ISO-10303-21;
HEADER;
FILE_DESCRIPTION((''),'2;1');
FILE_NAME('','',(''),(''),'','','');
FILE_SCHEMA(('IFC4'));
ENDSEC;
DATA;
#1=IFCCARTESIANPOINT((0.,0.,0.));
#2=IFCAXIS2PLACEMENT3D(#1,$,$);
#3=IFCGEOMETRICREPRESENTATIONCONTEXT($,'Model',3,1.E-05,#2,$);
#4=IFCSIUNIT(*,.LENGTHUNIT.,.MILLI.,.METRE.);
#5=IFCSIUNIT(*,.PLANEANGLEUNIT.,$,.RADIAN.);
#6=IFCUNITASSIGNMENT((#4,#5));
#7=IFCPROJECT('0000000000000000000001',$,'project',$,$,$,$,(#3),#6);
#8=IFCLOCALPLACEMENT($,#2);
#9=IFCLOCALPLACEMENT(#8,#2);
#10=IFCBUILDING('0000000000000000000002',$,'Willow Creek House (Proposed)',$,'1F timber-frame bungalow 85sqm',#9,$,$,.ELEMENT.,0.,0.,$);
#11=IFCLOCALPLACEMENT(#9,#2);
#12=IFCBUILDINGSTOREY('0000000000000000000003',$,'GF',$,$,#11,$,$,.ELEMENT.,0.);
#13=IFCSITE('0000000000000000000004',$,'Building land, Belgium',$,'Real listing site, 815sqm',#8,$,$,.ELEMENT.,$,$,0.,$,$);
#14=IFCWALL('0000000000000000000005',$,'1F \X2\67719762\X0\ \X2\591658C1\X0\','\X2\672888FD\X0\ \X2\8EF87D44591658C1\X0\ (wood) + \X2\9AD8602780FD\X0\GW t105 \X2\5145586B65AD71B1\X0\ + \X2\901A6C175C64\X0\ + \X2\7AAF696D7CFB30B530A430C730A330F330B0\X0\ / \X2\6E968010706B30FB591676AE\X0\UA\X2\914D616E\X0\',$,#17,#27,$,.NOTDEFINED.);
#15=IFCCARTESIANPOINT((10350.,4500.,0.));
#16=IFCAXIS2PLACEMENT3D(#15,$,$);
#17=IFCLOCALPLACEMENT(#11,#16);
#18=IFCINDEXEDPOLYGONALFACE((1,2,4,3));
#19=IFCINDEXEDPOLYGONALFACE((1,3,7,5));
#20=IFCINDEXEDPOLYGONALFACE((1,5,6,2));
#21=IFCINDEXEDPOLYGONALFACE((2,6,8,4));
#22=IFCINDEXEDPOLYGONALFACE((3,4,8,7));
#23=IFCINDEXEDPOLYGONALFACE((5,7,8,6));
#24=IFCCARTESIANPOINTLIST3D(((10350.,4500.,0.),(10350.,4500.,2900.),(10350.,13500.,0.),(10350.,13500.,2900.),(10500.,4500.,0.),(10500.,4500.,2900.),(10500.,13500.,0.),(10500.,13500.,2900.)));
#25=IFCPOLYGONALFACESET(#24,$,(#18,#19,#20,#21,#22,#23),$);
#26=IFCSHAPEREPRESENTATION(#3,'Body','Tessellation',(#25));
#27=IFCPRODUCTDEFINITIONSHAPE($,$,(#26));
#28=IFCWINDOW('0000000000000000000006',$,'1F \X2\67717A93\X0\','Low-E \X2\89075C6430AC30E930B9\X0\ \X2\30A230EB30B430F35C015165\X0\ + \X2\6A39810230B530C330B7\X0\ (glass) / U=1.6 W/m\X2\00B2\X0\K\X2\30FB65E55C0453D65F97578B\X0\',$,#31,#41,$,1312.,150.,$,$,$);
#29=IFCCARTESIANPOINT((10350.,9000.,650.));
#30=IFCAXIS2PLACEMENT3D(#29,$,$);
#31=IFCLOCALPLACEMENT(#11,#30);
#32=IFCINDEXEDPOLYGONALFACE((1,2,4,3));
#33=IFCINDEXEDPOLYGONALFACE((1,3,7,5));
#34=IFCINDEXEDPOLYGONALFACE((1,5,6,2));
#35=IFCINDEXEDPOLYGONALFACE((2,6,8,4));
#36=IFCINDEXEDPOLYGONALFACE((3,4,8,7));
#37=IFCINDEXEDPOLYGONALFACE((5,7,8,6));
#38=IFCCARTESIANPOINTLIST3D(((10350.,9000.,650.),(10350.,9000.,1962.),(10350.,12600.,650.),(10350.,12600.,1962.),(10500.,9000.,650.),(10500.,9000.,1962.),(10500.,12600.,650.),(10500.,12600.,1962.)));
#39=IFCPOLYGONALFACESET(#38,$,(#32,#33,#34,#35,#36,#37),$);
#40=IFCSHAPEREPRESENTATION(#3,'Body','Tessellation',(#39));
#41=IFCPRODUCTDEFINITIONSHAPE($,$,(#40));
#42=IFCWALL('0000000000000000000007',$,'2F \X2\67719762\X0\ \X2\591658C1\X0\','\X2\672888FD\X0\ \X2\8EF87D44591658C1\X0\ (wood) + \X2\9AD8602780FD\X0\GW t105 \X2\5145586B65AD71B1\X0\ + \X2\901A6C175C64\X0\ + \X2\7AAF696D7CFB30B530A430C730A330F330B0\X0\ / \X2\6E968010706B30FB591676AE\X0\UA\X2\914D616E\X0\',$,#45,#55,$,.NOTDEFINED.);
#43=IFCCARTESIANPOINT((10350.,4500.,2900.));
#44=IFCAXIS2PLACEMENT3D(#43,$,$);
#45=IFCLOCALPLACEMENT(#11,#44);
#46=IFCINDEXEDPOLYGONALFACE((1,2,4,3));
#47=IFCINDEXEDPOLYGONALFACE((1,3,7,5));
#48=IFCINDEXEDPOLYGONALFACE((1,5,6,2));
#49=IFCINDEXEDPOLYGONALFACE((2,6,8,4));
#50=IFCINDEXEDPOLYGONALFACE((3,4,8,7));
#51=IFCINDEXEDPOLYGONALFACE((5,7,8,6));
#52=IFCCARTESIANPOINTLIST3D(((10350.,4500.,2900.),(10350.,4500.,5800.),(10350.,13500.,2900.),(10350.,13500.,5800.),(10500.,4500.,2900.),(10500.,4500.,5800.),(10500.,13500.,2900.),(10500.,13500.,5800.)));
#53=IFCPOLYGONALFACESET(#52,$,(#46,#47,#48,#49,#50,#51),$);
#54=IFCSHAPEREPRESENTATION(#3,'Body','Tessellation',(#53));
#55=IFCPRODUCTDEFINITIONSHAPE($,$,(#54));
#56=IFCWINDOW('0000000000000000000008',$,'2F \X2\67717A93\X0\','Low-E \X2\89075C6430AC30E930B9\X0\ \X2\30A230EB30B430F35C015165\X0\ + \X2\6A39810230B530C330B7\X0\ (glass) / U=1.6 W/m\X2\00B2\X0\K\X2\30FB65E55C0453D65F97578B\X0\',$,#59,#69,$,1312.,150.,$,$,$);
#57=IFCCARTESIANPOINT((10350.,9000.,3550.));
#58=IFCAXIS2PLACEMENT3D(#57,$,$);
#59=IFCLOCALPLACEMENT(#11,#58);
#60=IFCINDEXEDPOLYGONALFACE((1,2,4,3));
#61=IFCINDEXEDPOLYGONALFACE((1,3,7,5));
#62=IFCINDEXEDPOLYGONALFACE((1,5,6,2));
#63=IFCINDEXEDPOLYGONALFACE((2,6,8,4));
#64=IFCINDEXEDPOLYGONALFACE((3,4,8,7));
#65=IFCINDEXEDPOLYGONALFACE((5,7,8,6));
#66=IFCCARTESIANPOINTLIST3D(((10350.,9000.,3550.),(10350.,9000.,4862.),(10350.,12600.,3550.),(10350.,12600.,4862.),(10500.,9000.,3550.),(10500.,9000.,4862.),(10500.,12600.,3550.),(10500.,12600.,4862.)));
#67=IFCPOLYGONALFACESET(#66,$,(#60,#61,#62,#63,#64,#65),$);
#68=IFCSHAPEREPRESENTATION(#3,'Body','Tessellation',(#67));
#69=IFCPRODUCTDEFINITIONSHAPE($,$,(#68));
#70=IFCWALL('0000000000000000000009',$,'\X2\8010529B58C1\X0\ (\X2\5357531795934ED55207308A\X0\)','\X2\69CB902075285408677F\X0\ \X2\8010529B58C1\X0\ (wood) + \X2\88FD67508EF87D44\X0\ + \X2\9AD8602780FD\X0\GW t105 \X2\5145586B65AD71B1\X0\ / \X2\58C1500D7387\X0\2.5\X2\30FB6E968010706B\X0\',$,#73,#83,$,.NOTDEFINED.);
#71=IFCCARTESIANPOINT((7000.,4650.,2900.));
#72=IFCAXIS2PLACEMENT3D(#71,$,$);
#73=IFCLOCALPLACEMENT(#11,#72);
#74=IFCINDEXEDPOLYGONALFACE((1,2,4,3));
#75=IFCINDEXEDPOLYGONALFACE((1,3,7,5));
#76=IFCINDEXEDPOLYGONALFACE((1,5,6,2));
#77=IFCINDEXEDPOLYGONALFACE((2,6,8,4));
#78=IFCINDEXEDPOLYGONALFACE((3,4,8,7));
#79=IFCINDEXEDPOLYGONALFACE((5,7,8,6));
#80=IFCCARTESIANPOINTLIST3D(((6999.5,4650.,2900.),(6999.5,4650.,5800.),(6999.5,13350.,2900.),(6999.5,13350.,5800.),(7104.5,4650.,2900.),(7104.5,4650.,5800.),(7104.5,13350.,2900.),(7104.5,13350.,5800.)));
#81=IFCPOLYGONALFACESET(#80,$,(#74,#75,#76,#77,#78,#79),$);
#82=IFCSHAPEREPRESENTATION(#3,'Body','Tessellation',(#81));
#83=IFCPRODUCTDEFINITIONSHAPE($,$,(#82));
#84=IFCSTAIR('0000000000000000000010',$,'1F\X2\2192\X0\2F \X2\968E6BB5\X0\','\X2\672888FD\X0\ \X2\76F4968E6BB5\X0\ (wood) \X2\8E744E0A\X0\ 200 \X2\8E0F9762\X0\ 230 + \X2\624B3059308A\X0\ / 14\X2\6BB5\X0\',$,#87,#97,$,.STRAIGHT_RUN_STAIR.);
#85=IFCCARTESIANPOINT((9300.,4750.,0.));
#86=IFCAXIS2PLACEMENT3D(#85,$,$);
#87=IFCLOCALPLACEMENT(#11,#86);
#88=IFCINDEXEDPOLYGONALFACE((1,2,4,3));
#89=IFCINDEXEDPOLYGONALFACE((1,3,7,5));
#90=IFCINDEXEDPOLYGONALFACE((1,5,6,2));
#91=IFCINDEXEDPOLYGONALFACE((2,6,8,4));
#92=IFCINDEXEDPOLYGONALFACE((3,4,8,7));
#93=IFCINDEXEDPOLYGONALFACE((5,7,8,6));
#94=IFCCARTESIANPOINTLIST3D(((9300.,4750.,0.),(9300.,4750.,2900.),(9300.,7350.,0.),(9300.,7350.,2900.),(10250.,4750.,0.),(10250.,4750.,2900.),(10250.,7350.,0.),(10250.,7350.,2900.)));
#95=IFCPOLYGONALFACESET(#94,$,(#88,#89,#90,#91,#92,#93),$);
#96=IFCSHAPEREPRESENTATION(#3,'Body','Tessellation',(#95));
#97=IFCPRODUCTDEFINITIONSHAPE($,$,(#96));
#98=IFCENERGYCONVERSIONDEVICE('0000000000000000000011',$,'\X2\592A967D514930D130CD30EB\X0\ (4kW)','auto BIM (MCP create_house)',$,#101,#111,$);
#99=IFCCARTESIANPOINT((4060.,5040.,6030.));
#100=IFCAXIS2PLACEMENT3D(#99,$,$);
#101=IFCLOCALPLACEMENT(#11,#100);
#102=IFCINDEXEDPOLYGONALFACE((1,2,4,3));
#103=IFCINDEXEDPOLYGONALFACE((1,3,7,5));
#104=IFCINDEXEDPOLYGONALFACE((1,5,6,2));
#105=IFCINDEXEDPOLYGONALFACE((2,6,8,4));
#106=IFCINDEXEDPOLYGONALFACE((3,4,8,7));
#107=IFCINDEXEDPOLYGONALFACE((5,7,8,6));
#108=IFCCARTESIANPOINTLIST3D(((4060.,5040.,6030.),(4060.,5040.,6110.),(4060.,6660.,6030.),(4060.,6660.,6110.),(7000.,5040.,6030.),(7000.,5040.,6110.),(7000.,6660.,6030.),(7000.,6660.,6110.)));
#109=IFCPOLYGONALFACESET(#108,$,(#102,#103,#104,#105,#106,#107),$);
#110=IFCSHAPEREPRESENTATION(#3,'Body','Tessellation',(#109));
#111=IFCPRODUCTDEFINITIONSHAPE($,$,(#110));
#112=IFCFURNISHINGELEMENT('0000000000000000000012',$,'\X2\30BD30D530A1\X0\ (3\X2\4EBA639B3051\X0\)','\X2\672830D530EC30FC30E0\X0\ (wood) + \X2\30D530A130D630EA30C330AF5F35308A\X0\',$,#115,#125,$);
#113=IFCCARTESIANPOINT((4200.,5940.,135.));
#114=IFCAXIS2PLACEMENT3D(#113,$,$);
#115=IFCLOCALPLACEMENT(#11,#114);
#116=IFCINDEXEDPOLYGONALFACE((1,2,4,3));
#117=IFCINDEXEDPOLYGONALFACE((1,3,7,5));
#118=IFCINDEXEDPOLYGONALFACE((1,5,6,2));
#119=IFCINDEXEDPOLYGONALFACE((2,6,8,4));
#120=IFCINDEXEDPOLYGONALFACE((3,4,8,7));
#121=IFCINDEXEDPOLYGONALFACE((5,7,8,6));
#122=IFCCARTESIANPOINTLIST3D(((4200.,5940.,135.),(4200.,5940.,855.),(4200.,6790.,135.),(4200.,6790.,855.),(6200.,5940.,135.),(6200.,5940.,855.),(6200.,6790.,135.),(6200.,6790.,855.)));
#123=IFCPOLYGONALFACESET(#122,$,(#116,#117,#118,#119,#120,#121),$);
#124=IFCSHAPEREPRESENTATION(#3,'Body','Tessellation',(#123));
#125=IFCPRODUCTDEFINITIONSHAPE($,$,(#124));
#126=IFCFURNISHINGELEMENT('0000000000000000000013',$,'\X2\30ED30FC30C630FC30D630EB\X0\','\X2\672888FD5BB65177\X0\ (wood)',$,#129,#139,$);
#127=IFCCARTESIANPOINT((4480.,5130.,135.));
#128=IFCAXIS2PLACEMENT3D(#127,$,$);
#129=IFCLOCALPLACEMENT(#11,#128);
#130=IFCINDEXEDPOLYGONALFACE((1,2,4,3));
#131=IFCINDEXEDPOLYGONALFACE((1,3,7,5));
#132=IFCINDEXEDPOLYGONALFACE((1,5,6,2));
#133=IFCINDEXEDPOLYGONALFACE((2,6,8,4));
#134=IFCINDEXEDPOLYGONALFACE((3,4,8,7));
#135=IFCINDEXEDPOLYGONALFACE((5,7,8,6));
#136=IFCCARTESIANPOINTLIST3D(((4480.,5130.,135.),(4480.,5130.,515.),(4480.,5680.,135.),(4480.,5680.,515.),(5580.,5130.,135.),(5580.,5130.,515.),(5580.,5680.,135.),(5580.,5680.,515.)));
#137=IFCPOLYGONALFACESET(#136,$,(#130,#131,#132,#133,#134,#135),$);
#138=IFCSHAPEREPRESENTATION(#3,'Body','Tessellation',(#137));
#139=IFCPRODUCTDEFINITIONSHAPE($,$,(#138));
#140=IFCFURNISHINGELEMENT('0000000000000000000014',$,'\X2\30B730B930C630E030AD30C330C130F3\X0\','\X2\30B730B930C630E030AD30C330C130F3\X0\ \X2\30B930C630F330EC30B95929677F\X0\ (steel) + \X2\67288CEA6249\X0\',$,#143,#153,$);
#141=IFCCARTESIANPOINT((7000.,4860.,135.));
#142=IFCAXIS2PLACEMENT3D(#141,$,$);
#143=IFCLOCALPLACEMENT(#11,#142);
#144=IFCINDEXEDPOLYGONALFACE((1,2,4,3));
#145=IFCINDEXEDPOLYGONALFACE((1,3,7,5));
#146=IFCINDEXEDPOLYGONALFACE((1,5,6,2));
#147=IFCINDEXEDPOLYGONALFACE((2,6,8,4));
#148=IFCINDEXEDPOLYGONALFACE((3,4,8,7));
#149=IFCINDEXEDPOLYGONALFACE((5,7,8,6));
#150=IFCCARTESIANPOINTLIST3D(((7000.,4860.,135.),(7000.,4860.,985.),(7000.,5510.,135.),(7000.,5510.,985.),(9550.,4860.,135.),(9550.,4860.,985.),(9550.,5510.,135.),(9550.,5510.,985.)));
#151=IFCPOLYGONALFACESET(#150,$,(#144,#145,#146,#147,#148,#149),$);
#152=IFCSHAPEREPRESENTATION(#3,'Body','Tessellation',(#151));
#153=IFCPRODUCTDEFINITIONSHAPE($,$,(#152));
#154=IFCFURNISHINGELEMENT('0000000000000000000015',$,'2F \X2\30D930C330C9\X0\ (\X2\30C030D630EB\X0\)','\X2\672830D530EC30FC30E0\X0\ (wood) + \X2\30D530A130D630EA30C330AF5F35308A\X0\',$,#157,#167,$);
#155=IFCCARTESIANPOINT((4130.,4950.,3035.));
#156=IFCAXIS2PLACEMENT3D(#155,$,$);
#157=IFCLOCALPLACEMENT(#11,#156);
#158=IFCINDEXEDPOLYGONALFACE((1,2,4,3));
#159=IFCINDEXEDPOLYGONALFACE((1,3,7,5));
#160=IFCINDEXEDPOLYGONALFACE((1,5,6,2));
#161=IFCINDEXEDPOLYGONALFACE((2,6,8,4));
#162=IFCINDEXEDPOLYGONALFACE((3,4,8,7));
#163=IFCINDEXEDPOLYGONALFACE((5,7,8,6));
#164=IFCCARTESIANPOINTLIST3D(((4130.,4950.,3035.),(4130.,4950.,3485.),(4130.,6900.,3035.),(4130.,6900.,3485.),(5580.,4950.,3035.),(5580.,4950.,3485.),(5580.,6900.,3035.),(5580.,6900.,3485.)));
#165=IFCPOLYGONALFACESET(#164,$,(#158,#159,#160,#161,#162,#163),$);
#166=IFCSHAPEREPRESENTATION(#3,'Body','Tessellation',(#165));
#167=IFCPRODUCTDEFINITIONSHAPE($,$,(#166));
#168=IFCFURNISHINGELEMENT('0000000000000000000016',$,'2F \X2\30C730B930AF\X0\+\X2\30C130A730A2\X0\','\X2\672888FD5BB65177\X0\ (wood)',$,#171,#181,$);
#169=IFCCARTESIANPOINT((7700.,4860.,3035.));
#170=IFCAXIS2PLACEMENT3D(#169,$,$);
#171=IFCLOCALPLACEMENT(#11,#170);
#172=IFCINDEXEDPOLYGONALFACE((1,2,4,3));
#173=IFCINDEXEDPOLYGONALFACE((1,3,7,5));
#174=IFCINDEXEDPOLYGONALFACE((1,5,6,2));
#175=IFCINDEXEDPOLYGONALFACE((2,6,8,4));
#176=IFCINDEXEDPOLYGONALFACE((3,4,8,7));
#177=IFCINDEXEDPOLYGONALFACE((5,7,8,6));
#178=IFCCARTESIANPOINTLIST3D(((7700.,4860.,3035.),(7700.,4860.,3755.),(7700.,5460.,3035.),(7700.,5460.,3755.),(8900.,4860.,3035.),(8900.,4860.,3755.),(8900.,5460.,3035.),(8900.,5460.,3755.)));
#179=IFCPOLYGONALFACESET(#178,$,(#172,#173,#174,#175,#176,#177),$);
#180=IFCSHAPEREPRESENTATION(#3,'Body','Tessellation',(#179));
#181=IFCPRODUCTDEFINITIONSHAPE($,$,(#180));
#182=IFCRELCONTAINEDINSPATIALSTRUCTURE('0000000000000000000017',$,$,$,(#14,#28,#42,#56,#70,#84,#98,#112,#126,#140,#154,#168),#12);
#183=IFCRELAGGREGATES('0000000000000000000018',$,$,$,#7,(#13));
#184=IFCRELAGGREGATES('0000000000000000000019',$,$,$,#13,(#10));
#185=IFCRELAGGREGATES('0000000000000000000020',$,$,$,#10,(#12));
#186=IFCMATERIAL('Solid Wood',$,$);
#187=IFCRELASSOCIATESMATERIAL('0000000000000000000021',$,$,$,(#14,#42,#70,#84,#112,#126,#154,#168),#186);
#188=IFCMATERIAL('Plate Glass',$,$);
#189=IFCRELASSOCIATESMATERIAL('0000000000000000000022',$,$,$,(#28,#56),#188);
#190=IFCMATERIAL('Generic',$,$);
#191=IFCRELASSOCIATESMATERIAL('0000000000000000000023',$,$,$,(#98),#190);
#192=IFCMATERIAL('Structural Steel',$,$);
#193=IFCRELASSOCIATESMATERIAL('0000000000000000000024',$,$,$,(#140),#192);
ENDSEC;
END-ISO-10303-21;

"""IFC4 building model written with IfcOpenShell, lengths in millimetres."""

from ifc_helpers import new_model, si_unit, frame, frame_2d, origin, place, context, project, spatial, rectangle, extrude, material, element, fill, save


model = new_model("IFC4")

# Units and contexts
model_context = context("Model", 3, precision=1e-05, world=origin())
ifc_project = project(units=[si_unit("LENGTHUNIT", "METRE", prefix="MILLI"), si_unit("PLANEANGLEUNIT", "RADIAN")], contexts=[model_context])

# Site, building, storey
site_placement = place(None, origin())
site = spatial("IfcSite", under=ifc_project, at=site_placement, Name="Building land, Belgium", ObjectType="Real listing site, 815sqm", CompositionType="ELEMENT", RefElevation=0.0)
building_placement = place(site_placement, origin())
building = spatial("IfcBuilding", under=site, at=building_placement, Name="Willow Creek House (Proposed)", ObjectType="1F timber-frame bungalow 85sqm", CompositionType="ELEMENT", ElevationOfRefHeight=0.0, ElevationOfTerrain=0.0)
storey_placement = place(building_placement, origin())
storey = spatial("IfcBuildingStorey", under=building, at=storey_placement, Name="GF", CompositionType="ELEMENT", Elevation=0.0)

# Wall, opening, window
ifc_material_1 = material(Name="Solid Wood")
wall_1_placement = place(storey_placement, frame((10350.0, 4500.0, 0.0)))
wall_1 = element("IfcWall", 1, at=wall_1_placement, inside=storey, material=ifc_material_1, Name="1F 東面 外壁", Description="木製 軸組外壁 (wood) + 高性能GW t105 充填断熱 + 通気層 + 窯業系サイディング / 準耐火・外皮UA配慮", PredefinedType="NOTDEFINED", context=model_context, shape_type="SweptSolid", body=[
    extrude(rectangle(XDim=150.0, YDim=9000.0, at=frame_2d((75.0, 4500.0))), frame((10350.0, 4500.0, 0.0)), (0.0, 0.0, 1.0), 2900.0),
])
opening_1_placement = place(storey_placement, frame((10350.0, 9000.0, 650.0)))
opening_1 = element("IfcOpeningElement", 2, at=opening_1_placement, cuts=wall_1, PredefinedType="NOTDEFINED", context=model_context, shape_type="SweptSolid", body=[
    extrude(rectangle(XDim=150.0, YDim=3600.0, at=frame_2d((75.0, 1800.0))), frame((10350.0, 9000.0, 650.0)), (0.0, 0.0, 1.0), 1312.0),
])
ifc_material_2 = material(Name="Plate Glass")
window_1_placement = place(storey_placement, frame((10350.0, 9000.0, 650.0)))
window_1 = element("IfcWindow", 3, at=window_1_placement, inside=storey, material=ifc_material_2, Name="1F 東窓", Description="Low-E 複層ガラス アルゴン封入 + 樹脂サッシ (glass) / U=1.6 W/m²K・日射取得型", OverallHeight=1312.0, OverallWidth=150.0, context=model_context, shape_type="SweptSolid", body=[
    extrude(rectangle(XDim=150.0, YDim=3600.0, at=frame_2d((75.0, 1800.0))), frame((10350.0, 9000.0, 650.0)), (0.0, 0.0, 1.0), 1312.0),
])
fill(opening_1, window_1)

# Wall, opening, window
wall_2_placement = place(storey_placement, frame((10350.0, 4500.0, 2900.0)))
wall_2 = element("IfcWall", 4, at=wall_2_placement, inside=storey, material=ifc_material_1, Name="2F 東面 外壁", Description="木製 軸組外壁 (wood) + 高性能GW t105 充填断熱 + 通気層 + 窯業系サイディング / 準耐火・外皮UA配慮", PredefinedType="NOTDEFINED", context=model_context, shape_type="SweptSolid", body=[
    extrude(rectangle(XDim=150.0, YDim=9000.0, at=frame_2d((75.0, 4500.0))), frame((10350.0, 4500.0, 2900.0)), (0.0, 0.0, 1.0), 2900.0),
])
opening_2_placement = place(storey_placement, frame((10350.0, 9000.0, 3550.0)))
opening_2 = element("IfcOpeningElement", 5, at=opening_2_placement, cuts=wall_2, PredefinedType="NOTDEFINED", context=model_context, shape_type="SweptSolid", body=[
    extrude(rectangle(XDim=150.0, YDim=3600.0, at=frame_2d((75.0, 1800.0))), frame((10350.0, 9000.0, 3550.0)), (0.0, 0.0, 1.0), 1312.0),
])
window_2_placement = place(storey_placement, frame((10350.0, 9000.0, 3550.0)))
window_2 = element("IfcWindow", 6, at=window_2_placement, inside=storey, material=ifc_material_2, Name="2F 東窓", Description="Low-E 複層ガラス アルゴン封入 + 樹脂サッシ (glass) / U=1.6 W/m²K・日射取得型", OverallHeight=1312.0, OverallWidth=150.0, context=model_context, shape_type="SweptSolid", body=[
    extrude(rectangle(XDim=150.0, YDim=3600.0, at=frame_2d((75.0, 1800.0))), frame((10350.0, 9000.0, 3550.0)), (0.0, 0.0, 1.0), 1312.0),
])
fill(opening_2, window_2)

# Wall
wall_3_placement = place(storey_placement, frame((7000.0, 4650.0, 2900.0)))
element("IfcWall", 7, at=wall_3_placement, inside=storey, material=ifc_material_1, Name="耐力壁 (南北間仕切り)", Description="構造用合板 耐力壁 (wood) + 製材軸組 + 高性能GW t105 充填断熱 / 壁倍率2.5・準耐火", PredefinedType="NOTDEFINED", context=model_context, shape_type="SweptSolid", body=[
    extrude(rectangle(XDim=105.0, YDim=8700.0, at=frame_2d((52.0, 4350.0))), frame((7000.0, 4650.0, 2900.0)), (0.0, 0.0, 1.0), 2900.0),
])

# Stair
stair_placement = place(storey_placement, frame((9300.0, 4750.0, 0.0)))
element("IfcStair", 8, at=stair_placement, inside=storey, material=ifc_material_1, Name="1F→2F 階段", Description="木製 直階段 (wood) 蹴上 200 踏面 230 + 手すり / 14段", PredefinedType="STRAIGHT_RUN_STAIR", context=model_context, shape_type="SweptSolid", body=[
    extrude(rectangle(XDim=950.0, YDim=2600.0, at=frame_2d((475.0, 1300.0))), frame((9300.0, 4750.0, 0.0)), (0.0, 0.0, 1.0), 2900.0),
])

# Energy conversion device
ifc_material_3 = material(Name="Generic")
energy_conversion_device_placement = place(storey_placement, frame((4060.0, 5040.0, 6030.0)))
element("IfcEnergyConversionDevice", 9, at=energy_conversion_device_placement, inside=storey, material=ifc_material_3, Name="太陽光パネル (4kW)", Description="auto BIM (MCP create_house)", context=model_context, shape_type="SweptSolid", body=[
    extrude(rectangle(XDim=2940.0, YDim=1620.0, at=frame_2d((1470.0, 810.0))), frame((4060.0, 5040.0, 6030.0)), (0.0, 0.0, 1.0), 80.0),
])

# Furnishing elements
furnishing_1_placement = place(storey_placement, frame((4200.0, 5940.0, 135.0)))
element("IfcFurnishingElement", 10, at=furnishing_1_placement, inside=storey, material=ifc_material_1, Name="ソファ (3人掛け)", Description="木フレーム (wood) + ファブリック張り", context=model_context, shape_type="SweptSolid", body=[
    extrude(rectangle(XDim=2000.0, YDim=850.0, at=frame_2d((1000.0, 425.0))), frame((4200.0, 5940.0, 135.0)), (0.0, 0.0, 1.0), 720.0),
])
furnishing_2_placement = place(storey_placement, frame((4480.0, 5130.0, 135.0)))
element("IfcFurnishingElement", 11, at=furnishing_2_placement, inside=storey, material=ifc_material_1, Name="ローテーブル", Description="木製家具 (wood)", context=model_context, shape_type="SweptSolid", body=[
    extrude(rectangle(XDim=1100.0, YDim=550.0, at=frame_2d((550.0, 275.0))), frame((4480.0, 5130.0, 135.0)), (0.0, 0.0, 1.0), 380.0),
])
ifc_material_4 = material(Name="Structural Steel")
furnishing_3_placement = place(storey_placement, frame((7000.0, 4860.0, 135.0)))
element("IfcFurnishingElement", 12, at=furnishing_3_placement, inside=storey, material=ifc_material_4, Name="システムキッチン", Description="システムキッチン ステンレス天板 (steel) + 木質扉", context=model_context, shape_type="SweptSolid", body=[
    extrude(rectangle(XDim=2550.0, YDim=650.0, at=frame_2d((1275.0, 325.0))), frame((7000.0, 4860.0, 135.0)), (0.0, 0.0, 1.0), 850.0),
])
furnishing_4_placement = place(storey_placement, frame((4130.0, 4950.0, 3035.0)))
element("IfcFurnishingElement", 13, at=furnishing_4_placement, inside=storey, material=ifc_material_1, Name="2F ベッド (ダブル)", Description="木フレーム (wood) + ファブリック張り", context=model_context, shape_type="SweptSolid", body=[
    extrude(rectangle(XDim=1450.0, YDim=1950.0, at=frame_2d((725.0, 975.0))), frame((4130.0, 4950.0, 3035.0)), (0.0, 0.0, 1.0), 450.0),
])
furnishing_5_placement = place(storey_placement, frame((7700.0, 4860.0, 3035.0)))
element("IfcFurnishingElement", 14, at=furnishing_5_placement, inside=storey, material=ifc_material_1, Name="2F デスク+チェア", Description="木製家具 (wood)", context=model_context, shape_type="SweptSolid", body=[
    extrude(rectangle(XDim=1200.0, YDim=600.0, at=frame_2d((600.0, 300.0))), frame((7700.0, 4860.0, 3035.0)), (0.0, 0.0, 1.0), 720.0),
])

save(model, "model.ifc")
